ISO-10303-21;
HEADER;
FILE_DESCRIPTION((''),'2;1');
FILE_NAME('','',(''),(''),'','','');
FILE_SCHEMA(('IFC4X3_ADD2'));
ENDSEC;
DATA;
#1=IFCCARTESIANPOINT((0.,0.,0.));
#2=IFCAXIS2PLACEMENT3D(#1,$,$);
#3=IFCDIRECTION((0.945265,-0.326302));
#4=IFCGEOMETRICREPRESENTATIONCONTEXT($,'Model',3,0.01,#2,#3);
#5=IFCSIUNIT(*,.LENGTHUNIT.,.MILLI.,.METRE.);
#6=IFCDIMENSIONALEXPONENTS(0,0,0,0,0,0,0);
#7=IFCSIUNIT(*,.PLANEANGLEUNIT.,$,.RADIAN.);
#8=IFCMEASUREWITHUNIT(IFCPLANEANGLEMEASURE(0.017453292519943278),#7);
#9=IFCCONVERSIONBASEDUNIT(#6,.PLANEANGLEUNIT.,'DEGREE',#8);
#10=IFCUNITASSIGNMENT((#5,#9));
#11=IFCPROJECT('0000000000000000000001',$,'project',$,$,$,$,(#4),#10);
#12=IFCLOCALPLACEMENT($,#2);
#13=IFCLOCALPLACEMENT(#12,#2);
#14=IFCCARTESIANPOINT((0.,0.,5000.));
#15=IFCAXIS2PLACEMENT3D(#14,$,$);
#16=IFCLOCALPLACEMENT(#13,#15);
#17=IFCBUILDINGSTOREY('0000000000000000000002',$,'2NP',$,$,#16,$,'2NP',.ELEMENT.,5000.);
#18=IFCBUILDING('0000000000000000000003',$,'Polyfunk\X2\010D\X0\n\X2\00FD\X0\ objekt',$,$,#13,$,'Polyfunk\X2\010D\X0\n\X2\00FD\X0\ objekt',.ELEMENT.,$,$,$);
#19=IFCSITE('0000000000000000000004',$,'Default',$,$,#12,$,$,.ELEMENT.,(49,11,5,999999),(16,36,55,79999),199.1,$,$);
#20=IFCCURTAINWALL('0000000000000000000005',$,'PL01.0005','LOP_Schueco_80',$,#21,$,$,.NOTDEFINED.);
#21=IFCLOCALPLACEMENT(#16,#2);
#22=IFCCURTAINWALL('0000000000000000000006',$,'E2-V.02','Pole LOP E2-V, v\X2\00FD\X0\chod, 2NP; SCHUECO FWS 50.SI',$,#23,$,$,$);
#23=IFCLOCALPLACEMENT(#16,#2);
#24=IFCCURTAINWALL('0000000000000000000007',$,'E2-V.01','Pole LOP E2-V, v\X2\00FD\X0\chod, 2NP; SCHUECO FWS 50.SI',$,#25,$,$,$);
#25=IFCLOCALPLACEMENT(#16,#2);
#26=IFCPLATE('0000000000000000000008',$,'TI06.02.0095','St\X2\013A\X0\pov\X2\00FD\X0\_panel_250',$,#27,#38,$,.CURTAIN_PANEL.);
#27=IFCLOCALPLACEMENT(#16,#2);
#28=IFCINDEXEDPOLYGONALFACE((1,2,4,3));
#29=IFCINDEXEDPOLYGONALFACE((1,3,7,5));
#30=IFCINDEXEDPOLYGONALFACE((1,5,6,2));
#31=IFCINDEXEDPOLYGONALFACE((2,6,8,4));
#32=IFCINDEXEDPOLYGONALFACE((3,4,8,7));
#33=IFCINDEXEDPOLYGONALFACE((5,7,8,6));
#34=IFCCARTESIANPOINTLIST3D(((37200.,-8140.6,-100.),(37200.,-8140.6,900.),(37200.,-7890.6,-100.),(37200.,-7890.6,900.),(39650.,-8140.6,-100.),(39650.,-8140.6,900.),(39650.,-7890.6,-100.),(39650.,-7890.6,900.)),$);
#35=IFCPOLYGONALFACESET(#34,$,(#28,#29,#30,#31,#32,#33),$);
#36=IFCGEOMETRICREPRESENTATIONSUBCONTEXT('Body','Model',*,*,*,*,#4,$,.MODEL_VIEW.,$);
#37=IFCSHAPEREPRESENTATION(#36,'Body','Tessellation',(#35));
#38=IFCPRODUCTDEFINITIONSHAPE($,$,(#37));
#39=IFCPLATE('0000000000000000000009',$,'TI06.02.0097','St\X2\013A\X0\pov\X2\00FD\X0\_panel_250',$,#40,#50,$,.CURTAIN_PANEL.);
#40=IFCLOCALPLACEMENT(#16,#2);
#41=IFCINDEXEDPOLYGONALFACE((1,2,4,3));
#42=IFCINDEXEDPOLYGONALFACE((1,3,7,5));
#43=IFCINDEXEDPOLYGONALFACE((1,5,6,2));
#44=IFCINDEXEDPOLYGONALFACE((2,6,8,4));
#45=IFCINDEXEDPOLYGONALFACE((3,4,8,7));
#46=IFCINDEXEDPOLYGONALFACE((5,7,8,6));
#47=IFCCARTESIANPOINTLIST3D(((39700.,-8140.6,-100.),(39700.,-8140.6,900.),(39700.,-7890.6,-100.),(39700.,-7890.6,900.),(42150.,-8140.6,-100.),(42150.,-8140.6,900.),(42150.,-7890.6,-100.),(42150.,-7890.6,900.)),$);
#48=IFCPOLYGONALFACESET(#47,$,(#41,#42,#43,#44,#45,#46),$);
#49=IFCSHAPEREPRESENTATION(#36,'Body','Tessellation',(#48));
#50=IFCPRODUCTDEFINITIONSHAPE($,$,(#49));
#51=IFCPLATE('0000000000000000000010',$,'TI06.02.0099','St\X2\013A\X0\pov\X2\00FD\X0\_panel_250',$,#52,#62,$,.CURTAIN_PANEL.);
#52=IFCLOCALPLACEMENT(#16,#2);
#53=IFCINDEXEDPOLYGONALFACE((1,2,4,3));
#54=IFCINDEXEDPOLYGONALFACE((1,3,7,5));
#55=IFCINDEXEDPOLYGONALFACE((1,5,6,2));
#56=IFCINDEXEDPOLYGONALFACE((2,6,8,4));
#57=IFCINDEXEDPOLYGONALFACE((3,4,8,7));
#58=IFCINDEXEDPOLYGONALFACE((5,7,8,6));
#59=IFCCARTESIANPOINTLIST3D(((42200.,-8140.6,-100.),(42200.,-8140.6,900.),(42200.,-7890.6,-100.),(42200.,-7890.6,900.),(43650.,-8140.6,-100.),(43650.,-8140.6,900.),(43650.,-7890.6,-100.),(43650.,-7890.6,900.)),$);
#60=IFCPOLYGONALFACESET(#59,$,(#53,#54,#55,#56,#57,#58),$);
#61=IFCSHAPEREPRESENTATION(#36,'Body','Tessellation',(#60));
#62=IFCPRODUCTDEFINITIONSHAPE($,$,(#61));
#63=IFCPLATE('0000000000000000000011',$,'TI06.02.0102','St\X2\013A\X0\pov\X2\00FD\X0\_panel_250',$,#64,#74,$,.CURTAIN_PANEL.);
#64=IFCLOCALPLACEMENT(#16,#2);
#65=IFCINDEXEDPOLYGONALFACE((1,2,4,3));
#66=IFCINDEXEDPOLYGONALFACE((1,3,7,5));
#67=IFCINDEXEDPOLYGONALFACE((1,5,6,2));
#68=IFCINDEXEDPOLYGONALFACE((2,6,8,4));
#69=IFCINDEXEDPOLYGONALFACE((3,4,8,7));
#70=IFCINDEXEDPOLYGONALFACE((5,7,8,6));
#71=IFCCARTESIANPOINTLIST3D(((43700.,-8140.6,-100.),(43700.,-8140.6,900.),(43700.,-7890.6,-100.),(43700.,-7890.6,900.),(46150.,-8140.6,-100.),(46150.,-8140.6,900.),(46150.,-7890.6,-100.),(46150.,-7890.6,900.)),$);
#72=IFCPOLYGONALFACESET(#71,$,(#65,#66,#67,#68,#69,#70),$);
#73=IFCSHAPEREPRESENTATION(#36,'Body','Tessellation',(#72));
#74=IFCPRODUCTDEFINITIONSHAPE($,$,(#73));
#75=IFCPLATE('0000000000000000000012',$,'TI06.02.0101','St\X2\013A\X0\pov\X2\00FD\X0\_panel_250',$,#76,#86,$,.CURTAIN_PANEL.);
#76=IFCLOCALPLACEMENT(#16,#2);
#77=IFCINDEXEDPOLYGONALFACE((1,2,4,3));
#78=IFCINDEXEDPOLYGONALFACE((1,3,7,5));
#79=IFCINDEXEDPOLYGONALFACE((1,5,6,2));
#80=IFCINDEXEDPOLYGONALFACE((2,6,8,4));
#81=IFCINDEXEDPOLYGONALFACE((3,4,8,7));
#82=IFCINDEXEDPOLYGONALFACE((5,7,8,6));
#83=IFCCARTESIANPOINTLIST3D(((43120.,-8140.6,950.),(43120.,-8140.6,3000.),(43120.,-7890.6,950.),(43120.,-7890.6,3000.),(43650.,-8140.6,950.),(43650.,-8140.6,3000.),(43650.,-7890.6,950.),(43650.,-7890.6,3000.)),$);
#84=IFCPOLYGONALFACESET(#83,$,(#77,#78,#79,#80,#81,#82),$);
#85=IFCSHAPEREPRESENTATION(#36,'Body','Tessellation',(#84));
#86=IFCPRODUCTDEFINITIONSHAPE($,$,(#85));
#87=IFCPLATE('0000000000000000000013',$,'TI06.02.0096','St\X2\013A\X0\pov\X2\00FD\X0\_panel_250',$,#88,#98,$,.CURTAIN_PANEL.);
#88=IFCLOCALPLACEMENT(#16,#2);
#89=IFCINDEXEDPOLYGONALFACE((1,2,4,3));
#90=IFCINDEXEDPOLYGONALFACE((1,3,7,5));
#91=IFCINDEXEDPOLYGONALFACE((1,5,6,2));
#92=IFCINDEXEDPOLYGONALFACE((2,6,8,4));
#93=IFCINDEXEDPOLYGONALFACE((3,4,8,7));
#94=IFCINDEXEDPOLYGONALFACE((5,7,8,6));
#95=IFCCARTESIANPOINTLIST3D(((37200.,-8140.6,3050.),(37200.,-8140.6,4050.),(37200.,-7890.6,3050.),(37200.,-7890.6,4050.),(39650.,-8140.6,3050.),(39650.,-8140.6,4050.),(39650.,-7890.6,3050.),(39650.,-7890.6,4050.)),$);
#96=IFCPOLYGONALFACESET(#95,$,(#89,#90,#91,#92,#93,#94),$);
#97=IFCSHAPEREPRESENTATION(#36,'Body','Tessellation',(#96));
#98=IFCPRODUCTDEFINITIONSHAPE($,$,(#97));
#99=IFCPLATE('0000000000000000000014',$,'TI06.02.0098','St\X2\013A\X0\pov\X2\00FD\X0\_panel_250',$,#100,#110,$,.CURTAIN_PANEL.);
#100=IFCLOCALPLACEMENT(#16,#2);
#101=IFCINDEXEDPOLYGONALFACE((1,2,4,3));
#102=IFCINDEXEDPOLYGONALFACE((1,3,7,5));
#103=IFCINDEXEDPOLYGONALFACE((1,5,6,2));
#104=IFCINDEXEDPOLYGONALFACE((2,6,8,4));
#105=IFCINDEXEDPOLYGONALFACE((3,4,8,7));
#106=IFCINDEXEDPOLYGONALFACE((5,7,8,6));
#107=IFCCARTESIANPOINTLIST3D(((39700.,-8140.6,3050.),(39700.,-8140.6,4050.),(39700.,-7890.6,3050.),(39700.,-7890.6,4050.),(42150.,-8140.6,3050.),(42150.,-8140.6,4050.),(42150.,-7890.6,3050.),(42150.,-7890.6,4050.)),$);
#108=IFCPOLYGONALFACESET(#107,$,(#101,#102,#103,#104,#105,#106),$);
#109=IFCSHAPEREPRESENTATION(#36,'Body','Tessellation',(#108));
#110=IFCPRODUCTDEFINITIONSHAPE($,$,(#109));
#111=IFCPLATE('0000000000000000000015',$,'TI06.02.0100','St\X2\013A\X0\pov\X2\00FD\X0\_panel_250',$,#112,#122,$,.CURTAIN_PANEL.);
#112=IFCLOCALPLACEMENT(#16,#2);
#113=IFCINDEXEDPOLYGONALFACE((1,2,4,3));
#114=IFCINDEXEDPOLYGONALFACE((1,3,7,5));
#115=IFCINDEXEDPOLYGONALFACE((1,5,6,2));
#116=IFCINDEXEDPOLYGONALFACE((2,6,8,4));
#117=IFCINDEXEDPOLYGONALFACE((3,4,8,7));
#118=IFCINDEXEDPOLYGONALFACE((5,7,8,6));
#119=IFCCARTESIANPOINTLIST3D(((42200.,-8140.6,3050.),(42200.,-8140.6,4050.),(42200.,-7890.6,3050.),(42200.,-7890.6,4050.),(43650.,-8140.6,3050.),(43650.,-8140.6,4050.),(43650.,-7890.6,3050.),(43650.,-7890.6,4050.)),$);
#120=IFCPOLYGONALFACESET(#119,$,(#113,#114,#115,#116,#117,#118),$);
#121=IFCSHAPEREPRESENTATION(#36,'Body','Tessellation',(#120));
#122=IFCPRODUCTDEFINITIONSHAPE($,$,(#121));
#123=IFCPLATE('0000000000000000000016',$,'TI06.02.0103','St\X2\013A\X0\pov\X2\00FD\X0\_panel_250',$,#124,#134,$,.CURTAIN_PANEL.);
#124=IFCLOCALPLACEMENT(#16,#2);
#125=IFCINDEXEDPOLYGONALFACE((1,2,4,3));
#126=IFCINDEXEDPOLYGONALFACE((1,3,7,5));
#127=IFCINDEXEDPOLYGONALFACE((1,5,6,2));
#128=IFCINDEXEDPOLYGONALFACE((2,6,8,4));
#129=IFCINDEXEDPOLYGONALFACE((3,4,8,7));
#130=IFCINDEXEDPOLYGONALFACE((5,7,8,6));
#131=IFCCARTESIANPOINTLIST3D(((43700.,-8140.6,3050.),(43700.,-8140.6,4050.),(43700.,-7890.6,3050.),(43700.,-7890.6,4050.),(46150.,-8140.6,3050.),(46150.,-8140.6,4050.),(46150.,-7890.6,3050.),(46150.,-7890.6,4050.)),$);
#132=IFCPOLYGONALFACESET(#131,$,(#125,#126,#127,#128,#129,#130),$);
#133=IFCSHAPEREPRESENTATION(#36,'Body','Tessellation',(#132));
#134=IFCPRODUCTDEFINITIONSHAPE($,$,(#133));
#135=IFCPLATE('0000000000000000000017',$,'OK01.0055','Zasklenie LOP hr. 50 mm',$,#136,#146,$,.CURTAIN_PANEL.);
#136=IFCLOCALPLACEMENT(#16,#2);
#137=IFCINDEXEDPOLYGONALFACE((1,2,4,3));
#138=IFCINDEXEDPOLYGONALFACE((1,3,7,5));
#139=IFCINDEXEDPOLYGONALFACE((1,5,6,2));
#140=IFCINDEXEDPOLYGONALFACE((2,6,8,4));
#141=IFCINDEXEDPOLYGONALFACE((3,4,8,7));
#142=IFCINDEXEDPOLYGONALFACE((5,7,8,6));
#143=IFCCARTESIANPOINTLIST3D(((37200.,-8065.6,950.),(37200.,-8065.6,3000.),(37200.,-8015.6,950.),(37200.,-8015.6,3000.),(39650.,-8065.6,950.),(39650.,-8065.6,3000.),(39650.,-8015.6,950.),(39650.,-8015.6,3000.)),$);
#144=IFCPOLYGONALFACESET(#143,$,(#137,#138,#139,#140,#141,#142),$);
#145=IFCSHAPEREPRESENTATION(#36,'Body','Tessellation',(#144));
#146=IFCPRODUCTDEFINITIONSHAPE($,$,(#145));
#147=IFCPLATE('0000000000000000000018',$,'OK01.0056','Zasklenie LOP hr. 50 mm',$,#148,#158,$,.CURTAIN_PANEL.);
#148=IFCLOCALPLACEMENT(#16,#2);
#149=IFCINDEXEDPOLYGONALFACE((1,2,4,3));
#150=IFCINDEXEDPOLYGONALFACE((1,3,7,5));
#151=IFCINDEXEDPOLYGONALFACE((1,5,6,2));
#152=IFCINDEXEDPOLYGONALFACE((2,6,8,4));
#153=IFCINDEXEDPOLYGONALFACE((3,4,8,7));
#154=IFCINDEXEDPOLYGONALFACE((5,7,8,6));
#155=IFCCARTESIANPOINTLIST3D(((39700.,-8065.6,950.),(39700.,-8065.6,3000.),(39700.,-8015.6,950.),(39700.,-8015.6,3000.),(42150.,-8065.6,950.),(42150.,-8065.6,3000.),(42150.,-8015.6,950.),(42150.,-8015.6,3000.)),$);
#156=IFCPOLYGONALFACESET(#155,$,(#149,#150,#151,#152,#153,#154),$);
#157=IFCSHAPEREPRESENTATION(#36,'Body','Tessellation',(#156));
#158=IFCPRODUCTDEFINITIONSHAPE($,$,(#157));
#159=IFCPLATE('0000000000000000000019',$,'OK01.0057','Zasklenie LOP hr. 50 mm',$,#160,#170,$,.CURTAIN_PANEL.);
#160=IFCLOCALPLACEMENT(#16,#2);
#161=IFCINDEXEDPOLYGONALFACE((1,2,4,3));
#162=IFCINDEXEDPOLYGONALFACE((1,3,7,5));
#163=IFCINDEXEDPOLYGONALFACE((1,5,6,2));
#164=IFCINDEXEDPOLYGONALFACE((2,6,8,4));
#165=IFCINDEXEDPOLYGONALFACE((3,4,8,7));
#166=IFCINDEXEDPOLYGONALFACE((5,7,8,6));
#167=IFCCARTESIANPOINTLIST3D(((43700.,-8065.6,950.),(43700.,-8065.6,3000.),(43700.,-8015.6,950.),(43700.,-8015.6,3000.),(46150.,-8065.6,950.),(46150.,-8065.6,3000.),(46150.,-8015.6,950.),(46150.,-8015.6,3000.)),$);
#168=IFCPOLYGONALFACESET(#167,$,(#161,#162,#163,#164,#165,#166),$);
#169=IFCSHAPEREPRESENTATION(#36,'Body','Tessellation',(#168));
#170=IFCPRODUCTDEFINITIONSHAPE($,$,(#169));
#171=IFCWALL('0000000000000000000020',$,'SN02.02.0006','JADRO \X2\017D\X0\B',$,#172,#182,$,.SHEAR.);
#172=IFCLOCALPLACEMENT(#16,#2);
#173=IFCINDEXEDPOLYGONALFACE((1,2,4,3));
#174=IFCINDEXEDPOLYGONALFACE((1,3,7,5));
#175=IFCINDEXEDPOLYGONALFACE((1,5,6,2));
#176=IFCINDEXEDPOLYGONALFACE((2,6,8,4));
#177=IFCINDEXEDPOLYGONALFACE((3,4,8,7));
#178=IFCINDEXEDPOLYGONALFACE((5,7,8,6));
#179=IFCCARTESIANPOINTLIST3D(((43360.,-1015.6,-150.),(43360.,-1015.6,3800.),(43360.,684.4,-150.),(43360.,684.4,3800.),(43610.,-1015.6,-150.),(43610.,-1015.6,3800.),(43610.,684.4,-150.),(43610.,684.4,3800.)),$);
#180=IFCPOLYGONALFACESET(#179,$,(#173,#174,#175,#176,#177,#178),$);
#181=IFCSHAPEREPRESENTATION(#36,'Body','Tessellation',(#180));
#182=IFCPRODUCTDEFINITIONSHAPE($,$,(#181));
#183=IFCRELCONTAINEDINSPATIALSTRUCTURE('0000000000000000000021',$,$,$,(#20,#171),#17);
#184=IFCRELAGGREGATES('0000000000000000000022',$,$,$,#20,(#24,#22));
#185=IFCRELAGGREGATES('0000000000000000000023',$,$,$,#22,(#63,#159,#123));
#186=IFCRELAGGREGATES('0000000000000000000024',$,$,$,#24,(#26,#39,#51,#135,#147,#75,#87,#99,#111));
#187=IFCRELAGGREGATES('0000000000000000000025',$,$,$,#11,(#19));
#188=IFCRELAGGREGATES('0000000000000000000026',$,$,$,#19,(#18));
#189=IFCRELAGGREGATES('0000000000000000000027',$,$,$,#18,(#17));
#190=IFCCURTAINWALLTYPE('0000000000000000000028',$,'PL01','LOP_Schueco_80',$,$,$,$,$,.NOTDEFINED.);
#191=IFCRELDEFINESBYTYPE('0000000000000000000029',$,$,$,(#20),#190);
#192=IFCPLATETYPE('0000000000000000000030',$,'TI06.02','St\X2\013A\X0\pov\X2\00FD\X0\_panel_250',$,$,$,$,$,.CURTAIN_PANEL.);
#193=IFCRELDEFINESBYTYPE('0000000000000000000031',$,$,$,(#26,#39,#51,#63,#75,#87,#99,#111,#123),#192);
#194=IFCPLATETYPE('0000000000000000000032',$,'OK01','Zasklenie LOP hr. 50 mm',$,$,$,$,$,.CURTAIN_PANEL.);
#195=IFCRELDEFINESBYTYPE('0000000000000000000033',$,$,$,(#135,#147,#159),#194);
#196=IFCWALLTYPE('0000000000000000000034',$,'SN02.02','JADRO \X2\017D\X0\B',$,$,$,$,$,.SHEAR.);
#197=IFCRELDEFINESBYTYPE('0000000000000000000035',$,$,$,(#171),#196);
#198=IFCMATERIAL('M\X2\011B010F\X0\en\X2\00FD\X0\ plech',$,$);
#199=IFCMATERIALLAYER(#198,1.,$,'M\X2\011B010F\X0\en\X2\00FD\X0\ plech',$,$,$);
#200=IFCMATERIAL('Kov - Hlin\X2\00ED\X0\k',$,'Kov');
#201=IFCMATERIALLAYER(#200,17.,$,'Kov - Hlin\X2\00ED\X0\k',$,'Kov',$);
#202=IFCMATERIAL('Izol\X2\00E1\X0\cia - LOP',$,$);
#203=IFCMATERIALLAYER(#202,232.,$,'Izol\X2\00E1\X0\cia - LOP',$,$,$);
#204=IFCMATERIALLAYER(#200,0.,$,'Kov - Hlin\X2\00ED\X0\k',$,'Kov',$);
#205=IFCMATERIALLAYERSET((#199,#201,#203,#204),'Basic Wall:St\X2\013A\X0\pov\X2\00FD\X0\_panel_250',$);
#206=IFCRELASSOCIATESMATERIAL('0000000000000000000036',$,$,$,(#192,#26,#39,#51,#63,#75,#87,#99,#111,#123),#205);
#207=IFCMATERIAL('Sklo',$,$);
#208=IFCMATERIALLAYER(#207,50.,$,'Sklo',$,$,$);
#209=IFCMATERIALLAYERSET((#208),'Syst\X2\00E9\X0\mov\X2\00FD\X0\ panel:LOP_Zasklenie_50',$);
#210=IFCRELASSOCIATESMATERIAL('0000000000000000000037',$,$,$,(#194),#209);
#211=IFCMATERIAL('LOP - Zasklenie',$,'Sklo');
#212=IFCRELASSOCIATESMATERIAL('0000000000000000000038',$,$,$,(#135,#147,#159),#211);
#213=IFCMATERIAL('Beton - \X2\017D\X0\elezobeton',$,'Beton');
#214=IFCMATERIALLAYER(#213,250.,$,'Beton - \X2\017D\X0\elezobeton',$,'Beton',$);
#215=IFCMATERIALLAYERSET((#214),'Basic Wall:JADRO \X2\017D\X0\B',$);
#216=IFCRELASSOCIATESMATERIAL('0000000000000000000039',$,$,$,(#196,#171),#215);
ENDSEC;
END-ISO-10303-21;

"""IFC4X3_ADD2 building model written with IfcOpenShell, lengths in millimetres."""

from ifc_helpers import new_model, entity, si_unit, converted_unit, direction, frame, frame_2d, origin, origin_2d_with_axis, place, context, subcontext, project, spatial, polyline, rectangle, extrude, clip, bounded_halfspace, source, transform, mapped, material, layer, layer_set, layer_usage, type_object, type_shapes, element, aggregate, save


model = new_model("IFC4X3_ADD2")

# Units and contexts
model_context = context("Model", 3, precision=0.01, world=origin(), true_north=direction((0.945265, -0.326302)))
body_context = subcontext(model_context, "Body", "Model", "MODEL_VIEW")
ifc_project = project(units=[si_unit("LENGTHUNIT", "METRE", prefix="MILLI"), converted_unit("PLANEANGLEUNIT", "DEGREE", entity("IfcPlaneAngleMeasure", 0.017453292519943278), si_unit("PLANEANGLEUNIT", "RADIAN"), dimensions=[0, 0, 0, 0, 0, 0, 0])], contexts=[model_context])

# Site, building, storey
site_placement = place(None, origin())
site = spatial("IfcSite", under=ifc_project, at=site_placement, Name="Default", CompositionType="ELEMENT", RefLatitude=(49, 11, 5, 999999), RefLongitude=(16, 36, 55, 79999), RefElevation=199.1)
building_placement = place(site_placement, origin())
building = spatial("IfcBuilding", under=site, at=building_placement, Name="Polyfunkčný objekt", LongName="Polyfunkčný objekt", CompositionType="ELEMENT")
storey_placement = place(building_placement, frame((0.0, 0.0, 5000.0)))
storey = spatial("IfcBuildingStorey", under=building, at=storey_placement, Name="2NP", LongName="2NP", CompositionType="ELEMENT", Elevation=5000.0)

# Curtain walls, plates
curtain_wall_type = type_object("IfcCurtainWallType", Name="PL01", Description="LOP_Schueco_80", PredefinedType="NOTDEFINED")
curtain_wall_1_placement = place(storey_placement, frame((0.0, 0.0, -5000.0)))
curtain_wall_1 = element("IfcCurtainWall", 1, at=curtain_wall_1_placement, inside=storey, type_object=curtain_wall_type, Name="PL01.0005", Description="LOP_Schueco_80", PredefinedType="NOTDEFINED")
curtain_wall_2 = element("IfcCurtainWall", 2, Name="E2-V.02", Description="Pole LOP E2-V, východ, 2NP; SCHUECO FWS 50.SI")
curtain_wall_3 = element("IfcCurtainWall", 3, Name="E2-V.01", Description="Pole LOP E2-V, východ, 2NP; SCHUECO FWS 50.SI")
aggregate(curtain_wall_1, [curtain_wall_3, curtain_wall_2])
ifc_material_1 = material(Name="Měďený plech")
ifc_layer_1 = layer(ifc_material_1, 1.0, Name="Měďený plech")
ifc_material_2 = material(Name="Kov - Hliník", Category="Kov")
ifc_layer_2 = layer(ifc_material_2, 17.0, Name="Kov - Hliník", Category="Kov")
ifc_material_3 = material(Name="Izolácia - LOP")
ifc_layer_3 = layer(ifc_material_3, 232.0, Name="Izolácia - LOP")
ifc_layer_4 = layer(ifc_material_2, 0.0, Name="Kov - Hliník", Category="Kov")
ifc_layer_set_1 = layer_set([ifc_layer_1, ifc_layer_2, ifc_layer_3, ifc_layer_4], Name="Basic Wall:Stĺpový_panel_250")
ifc_layer_usage_1 = layer_usage(ifc_layer_set_1, "AXIS2", "POSITIVE", -125.0)
plate_type_1 = type_object("IfcPlateType", Name="TI06.02", Description="Stĺpový_panel_250", PredefinedType="CURTAIN_PANEL", material=ifc_layer_set_1)
plate_1_placement = place(storey_placement, frame((37200.0, -8015.6, -100.0)))
plate_1 = element("IfcPlate", 4, at=plate_1_placement, type_object=plate_type_1, material=ifc_layer_usage_1, Name="TI06.02.0095", Description="Stĺpový_panel_250", PredefinedType="CURTAIN_PANEL", context=body_context, shape_type="SweptSolid", body=[
    extrude(rectangle(XDim=250.0, YDim=2450.0, at=frame_2d((0.0, 0.0), x_axis=(1.0, 0.0))), frame((1225.0, 0.0, 0.0), z_axis=(0.0, 0.0, 1.0), x_axis=(0.0, 1.0, 0.0)), (0.0, 0.0, 1.0), 1000.0),
])
ifc_layer_usage_2 = layer_usage(ifc_layer_set_1, "AXIS2", "POSITIVE", -125.0)
plate_2_placement = place(storey_placement, frame((39700.0, -8015.6, -100.0)))
plate_2 = element("IfcPlate", 5, at=plate_2_placement, type_object=plate_type_1, material=ifc_layer_usage_2, Name="TI06.02.0097", Description="Stĺpový_panel_250", PredefinedType="CURTAIN_PANEL", context=body_context, shape_type="SweptSolid", body=[
    extrude(rectangle(XDim=250.0, YDim=2450.0, at=frame_2d((0.0, 0.0), x_axis=(1.0, 0.0))), frame((1225.0, 0.0, 0.0), z_axis=(0.0, 0.0, 1.0), x_axis=(0.0, 1.0, 0.0)), (0.0, 0.0, 1.0), 1000.0),
])
ifc_layer_usage_3 = layer_usage(ifc_layer_set_1, "AXIS2", "POSITIVE", -125.0)
plate_3_placement = place(storey_placement, frame((42200.0, -8015.6, -100.0)))
plate_3 = element("IfcPlate", 6, at=plate_3_placement, type_object=plate_type_1, material=ifc_layer_usage_3, Name="TI06.02.0099", Description="Stĺpový_panel_250", PredefinedType="CURTAIN_PANEL", context=body_context, shape_type="SweptSolid", body=[
    extrude(rectangle(XDim=250.0, YDim=1450.0, at=frame_2d((0.0, 0.0), x_axis=(1.0, 0.0))), frame((725.0, 0.0, 0.0), z_axis=(0.0, 0.0, 1.0), x_axis=(0.0, 1.0, 0.0)), (0.0, 0.0, 1.0), 1000.0),
])
ifc_layer_usage_4 = layer_usage(ifc_layer_set_1, "AXIS2", "POSITIVE", -125.0)
plate_4_placement = place(storey_placement, frame((43700.0, -8015.6, -100.0)))
plate_4 = element("IfcPlate", 7, at=plate_4_placement, type_object=plate_type_1, material=ifc_layer_usage_4, Name="TI06.02.0102", Description="Stĺpový_panel_250", PredefinedType="CURTAIN_PANEL", context=body_context, shape_type="SweptSolid", body=[
    extrude(rectangle(XDim=250.0, YDim=2450.0, at=frame_2d((0.0, 0.0), x_axis=(1.0, 0.0))), frame((1225.0, 0.0, 0.0), z_axis=(0.0, 0.0, 1.0), x_axis=(0.0, 1.0, 0.0)), (0.0, 0.0, 1.0), 1000.0),
])
ifc_layer_usage_5 = layer_usage(ifc_layer_set_1, "AXIS2", "POSITIVE", -125.0)
plate_5_placement = place(storey_placement, frame((43120.0, -8015.6, 950.0)))
plate_5 = element("IfcPlate", 8, at=plate_5_placement, type_object=plate_type_1, material=ifc_layer_usage_5, Name="TI06.02.0101", Description="Stĺpový_panel_250", PredefinedType="CURTAIN_PANEL", context=body_context, shape_type="SweptSolid", body=[
    extrude(rectangle(XDim=250.0, YDim=530.0, at=frame_2d((0.0, 0.0), x_axis=(1.0, 0.0))), frame((265.0, 0.0, 0.0), z_axis=(0.0, 0.0, 1.0), x_axis=(0.0, 1.0, 0.0)), (0.0, 0.0, 1.0), 2050.0),
])
ifc_layer_usage_6 = layer_usage(ifc_layer_set_1, "AXIS2", "POSITIVE", -125.0)
plate_6_placement = place(storey_placement, frame((37200.0, -8015.6, 3050.0)))
plate_6 = element("IfcPlate", 9, at=plate_6_placement, type_object=plate_type_1, material=ifc_layer_usage_6, Name="TI06.02.0096", Description="Stĺpový_panel_250", PredefinedType="CURTAIN_PANEL", context=body_context, shape_type="SweptSolid", body=[
    extrude(rectangle(XDim=250.0, YDim=2450.0, at=frame_2d((0.0, 0.0), x_axis=(1.0, 0.0))), frame((1225.0, 0.0, 0.0), z_axis=(0.0, 0.0, 1.0), x_axis=(0.0, 1.0, 0.0)), (0.0, 0.0, 1.0), 1000.0),
])
ifc_layer_usage_7 = layer_usage(ifc_layer_set_1, "AXIS2", "POSITIVE", -125.0)
plate_7_placement = place(storey_placement, frame((39700.0, -8015.6, 3050.0)))
plate_7 = element("IfcPlate", 10, at=plate_7_placement, type_object=plate_type_1, material=ifc_layer_usage_7, Name="TI06.02.0098", Description="Stĺpový_panel_250", PredefinedType="CURTAIN_PANEL", context=body_context, shape_type="SweptSolid", body=[
    extrude(rectangle(XDim=250.0, YDim=2450.0, at=frame_2d((0.0, 0.0), x_axis=(1.0, 0.0))), frame((1225.0, 0.0, 0.0), z_axis=(0.0, 0.0, 1.0), x_axis=(0.0, 1.0, 0.0)), (0.0, 0.0, 1.0), 1000.0),
])
ifc_layer_usage_8 = layer_usage(ifc_layer_set_1, "AXIS2", "POSITIVE", -125.0)
plate_8_placement = place(storey_placement, frame((42200.0, -8015.6, 3050.0)))
plate_8 = element("IfcPlate", 11, at=plate_8_placement, type_object=plate_type_1, material=ifc_layer_usage_8, Name="TI06.02.0100", Description="Stĺpový_panel_250", PredefinedType="CURTAIN_PANEL", context=body_context, shape_type="SweptSolid", body=[
    extrude(rectangle(XDim=250.0, YDim=1450.0, at=frame_2d((0.0, 0.0), x_axis=(1.0, 0.0))), frame((725.0, 0.0, 0.0), z_axis=(0.0, 0.0, 1.0), x_axis=(0.0, 1.0, 0.0)), (0.0, 0.0, 1.0), 1000.0),
])
ifc_layer_usage_9 = layer_usage(ifc_layer_set_1, "AXIS2", "POSITIVE", -125.0)
plate_9_placement = place(storey_placement, frame((43700.0, -8015.6, 3050.0)))
plate_9 = element("IfcPlate", 12, at=plate_9_placement, type_object=plate_type_1, material=ifc_layer_usage_9, Name="TI06.02.0103", Description="Stĺpový_panel_250", PredefinedType="CURTAIN_PANEL", context=body_context, shape_type="SweptSolid", body=[
    extrude(rectangle(XDim=250.0, YDim=2450.0, at=frame_2d((0.0, 0.0), x_axis=(1.0, 0.0))), frame((1225.0, 0.0, 0.0), z_axis=(0.0, 0.0, 1.0), x_axis=(0.0, 1.0, 0.0)), (0.0, 0.0, 1.0), 1000.0),
])
ifc_material_4 = material(Name="LOP - Zasklenie", Category="Sklo")
ifc_material_5 = material(Name="Sklo")
ifc_layer_5 = layer(ifc_material_5, 50.0, Name="Sklo")
ifc_layer_set_2 = layer_set([ifc_layer_5], Name="Systémový panel:LOP_Zasklenie_50")
plate_type_2 = type_object("IfcPlateType", Name="OK01", Description="Zasklenie LOP hr. 50 mm", PredefinedType="CURTAIN_PANEL", material=ifc_layer_set_2)
shared_shape_1 = source(origin(), body_context, "Body", "SweptSolid", [
    extrude(rectangle(XDim=50.0, YDim=2450.0, at=origin_2d_with_axis()), frame((0.0, -25.0, 0.0), z_axis=(0.0, 0.0, 1.0), x_axis=(0.0, 1.0, 0.0)), (0.0, 0.0, 1.0), 2050.0),
])
type_shapes(plate_type_2, [shared_shape_1])
plate_10_placement = place(curtain_wall_1_placement, frame((38425.0, -8015.6, 5950.0)))
plate_10 = element("IfcPlate", 13, at=plate_10_placement, type_object=plate_type_2, material=ifc_material_4, Name="OK01.0055", Description="Zasklenie LOP hr. 50 mm", PredefinedType="CURTAIN_PANEL", context=body_context, shape_type="MappedRepresentation", body=[
    mapped(shared_shape_1, transform((0.0, 0.0, 0.0), scale=1.0)),
])
plate_11_placement = place(curtain_wall_1_placement, frame((40925.0, -8015.6, 5950.0)))
plate_11 = element("IfcPlate", 14, at=plate_11_placement, type_object=plate_type_2, material=ifc_material_4, Name="OK01.0056", Description="Zasklenie LOP hr. 50 mm", PredefinedType="CURTAIN_PANEL", context=body_context, shape_type="MappedRepresentation", body=[
    mapped(shared_shape_1, transform((0.0, 0.0, 0.0), scale=1.0)),
])
plate_12_placement = place(curtain_wall_1_placement, frame((44925.0, -8015.6, 5950.0)))
plate_12 = element("IfcPlate", 15, at=plate_12_placement, type_object=plate_type_2, material=ifc_material_4, Name="OK01.0057", Description="Zasklenie LOP hr. 50 mm", PredefinedType="CURTAIN_PANEL", context=body_context, shape_type="MappedRepresentation", body=[
    mapped(shared_shape_1, transform((0.0, 0.0, 0.0), scale=1.0)),
])
aggregate(curtain_wall_2, [plate_4, plate_12, plate_9])

# Wall
ifc_material_6 = material(Name="Beton - Železobeton", Category="Beton")
ifc_layer_6 = layer(ifc_material_6, 250.0, Name="Beton - Železobeton", Category="Beton")
ifc_layer_set_3 = layer_set([ifc_layer_6], Name="Basic Wall:JADRO ŽB")
wall_type = type_object("IfcWallType", Name="SN02.02", Description="JADRO ŽB", PredefinedType="SHEAR", material=ifc_layer_set_3)
placement = place(building_placement, origin())
wall_1_placement = place(placement, frame((43485.0, 684.4, 4850.0), z_axis=(0.0, 0.0, 1.0), x_axis=(0.0, -1.0, 0.0)))
element("IfcWall", 16, at=wall_1_placement, inside=storey, type_object=wall_type, material=ifc_layer_set_3, Name="SN02.02.0006", Description="JADRO ŽB", PredefinedType="SHEAR", context=body_context, shape_type="Clipping", body=[
    clip(clip(extrude(rectangle(XDim=1700.0, YDim=250.0, at=frame_2d((850.0, 0.0), x_axis=(-1.0, 0.0))), origin(), (0.0, 0.0, 1.0), 3950.0), bounded_halfspace(frame((1700.0, -125.0, 0.0), z_axis=(0.0, 0.0, 1.0), x_axis=(0.0, -1.0, 0.0)), True, frame((1700.0, -125.0, 0.0)), polyline([(0.0, 0.0), (0.0, 250.0), (-1700.0, 250.0), (-1700.0, 0.0), (0.0, 0.0)]))), bounded_halfspace(frame((0.0, -125.0, 3950.0), z_axis=(0.0, 0.0, -1.0), x_axis=(0.0, 1.0, 0.0)), True, frame((0.0, -125.0, 3950.0)), polyline([(0.0, 0.0), (1700.0, 0.0), (1700.0, 250.0), (0.0, 250.0), (0.0, 0.0)]))),
])

aggregate(curtain_wall_3, [plate_1, plate_2, plate_3, plate_10, plate_11, plate_5, plate_6, plate_7, plate_8])

save(model, "model.ifc")
